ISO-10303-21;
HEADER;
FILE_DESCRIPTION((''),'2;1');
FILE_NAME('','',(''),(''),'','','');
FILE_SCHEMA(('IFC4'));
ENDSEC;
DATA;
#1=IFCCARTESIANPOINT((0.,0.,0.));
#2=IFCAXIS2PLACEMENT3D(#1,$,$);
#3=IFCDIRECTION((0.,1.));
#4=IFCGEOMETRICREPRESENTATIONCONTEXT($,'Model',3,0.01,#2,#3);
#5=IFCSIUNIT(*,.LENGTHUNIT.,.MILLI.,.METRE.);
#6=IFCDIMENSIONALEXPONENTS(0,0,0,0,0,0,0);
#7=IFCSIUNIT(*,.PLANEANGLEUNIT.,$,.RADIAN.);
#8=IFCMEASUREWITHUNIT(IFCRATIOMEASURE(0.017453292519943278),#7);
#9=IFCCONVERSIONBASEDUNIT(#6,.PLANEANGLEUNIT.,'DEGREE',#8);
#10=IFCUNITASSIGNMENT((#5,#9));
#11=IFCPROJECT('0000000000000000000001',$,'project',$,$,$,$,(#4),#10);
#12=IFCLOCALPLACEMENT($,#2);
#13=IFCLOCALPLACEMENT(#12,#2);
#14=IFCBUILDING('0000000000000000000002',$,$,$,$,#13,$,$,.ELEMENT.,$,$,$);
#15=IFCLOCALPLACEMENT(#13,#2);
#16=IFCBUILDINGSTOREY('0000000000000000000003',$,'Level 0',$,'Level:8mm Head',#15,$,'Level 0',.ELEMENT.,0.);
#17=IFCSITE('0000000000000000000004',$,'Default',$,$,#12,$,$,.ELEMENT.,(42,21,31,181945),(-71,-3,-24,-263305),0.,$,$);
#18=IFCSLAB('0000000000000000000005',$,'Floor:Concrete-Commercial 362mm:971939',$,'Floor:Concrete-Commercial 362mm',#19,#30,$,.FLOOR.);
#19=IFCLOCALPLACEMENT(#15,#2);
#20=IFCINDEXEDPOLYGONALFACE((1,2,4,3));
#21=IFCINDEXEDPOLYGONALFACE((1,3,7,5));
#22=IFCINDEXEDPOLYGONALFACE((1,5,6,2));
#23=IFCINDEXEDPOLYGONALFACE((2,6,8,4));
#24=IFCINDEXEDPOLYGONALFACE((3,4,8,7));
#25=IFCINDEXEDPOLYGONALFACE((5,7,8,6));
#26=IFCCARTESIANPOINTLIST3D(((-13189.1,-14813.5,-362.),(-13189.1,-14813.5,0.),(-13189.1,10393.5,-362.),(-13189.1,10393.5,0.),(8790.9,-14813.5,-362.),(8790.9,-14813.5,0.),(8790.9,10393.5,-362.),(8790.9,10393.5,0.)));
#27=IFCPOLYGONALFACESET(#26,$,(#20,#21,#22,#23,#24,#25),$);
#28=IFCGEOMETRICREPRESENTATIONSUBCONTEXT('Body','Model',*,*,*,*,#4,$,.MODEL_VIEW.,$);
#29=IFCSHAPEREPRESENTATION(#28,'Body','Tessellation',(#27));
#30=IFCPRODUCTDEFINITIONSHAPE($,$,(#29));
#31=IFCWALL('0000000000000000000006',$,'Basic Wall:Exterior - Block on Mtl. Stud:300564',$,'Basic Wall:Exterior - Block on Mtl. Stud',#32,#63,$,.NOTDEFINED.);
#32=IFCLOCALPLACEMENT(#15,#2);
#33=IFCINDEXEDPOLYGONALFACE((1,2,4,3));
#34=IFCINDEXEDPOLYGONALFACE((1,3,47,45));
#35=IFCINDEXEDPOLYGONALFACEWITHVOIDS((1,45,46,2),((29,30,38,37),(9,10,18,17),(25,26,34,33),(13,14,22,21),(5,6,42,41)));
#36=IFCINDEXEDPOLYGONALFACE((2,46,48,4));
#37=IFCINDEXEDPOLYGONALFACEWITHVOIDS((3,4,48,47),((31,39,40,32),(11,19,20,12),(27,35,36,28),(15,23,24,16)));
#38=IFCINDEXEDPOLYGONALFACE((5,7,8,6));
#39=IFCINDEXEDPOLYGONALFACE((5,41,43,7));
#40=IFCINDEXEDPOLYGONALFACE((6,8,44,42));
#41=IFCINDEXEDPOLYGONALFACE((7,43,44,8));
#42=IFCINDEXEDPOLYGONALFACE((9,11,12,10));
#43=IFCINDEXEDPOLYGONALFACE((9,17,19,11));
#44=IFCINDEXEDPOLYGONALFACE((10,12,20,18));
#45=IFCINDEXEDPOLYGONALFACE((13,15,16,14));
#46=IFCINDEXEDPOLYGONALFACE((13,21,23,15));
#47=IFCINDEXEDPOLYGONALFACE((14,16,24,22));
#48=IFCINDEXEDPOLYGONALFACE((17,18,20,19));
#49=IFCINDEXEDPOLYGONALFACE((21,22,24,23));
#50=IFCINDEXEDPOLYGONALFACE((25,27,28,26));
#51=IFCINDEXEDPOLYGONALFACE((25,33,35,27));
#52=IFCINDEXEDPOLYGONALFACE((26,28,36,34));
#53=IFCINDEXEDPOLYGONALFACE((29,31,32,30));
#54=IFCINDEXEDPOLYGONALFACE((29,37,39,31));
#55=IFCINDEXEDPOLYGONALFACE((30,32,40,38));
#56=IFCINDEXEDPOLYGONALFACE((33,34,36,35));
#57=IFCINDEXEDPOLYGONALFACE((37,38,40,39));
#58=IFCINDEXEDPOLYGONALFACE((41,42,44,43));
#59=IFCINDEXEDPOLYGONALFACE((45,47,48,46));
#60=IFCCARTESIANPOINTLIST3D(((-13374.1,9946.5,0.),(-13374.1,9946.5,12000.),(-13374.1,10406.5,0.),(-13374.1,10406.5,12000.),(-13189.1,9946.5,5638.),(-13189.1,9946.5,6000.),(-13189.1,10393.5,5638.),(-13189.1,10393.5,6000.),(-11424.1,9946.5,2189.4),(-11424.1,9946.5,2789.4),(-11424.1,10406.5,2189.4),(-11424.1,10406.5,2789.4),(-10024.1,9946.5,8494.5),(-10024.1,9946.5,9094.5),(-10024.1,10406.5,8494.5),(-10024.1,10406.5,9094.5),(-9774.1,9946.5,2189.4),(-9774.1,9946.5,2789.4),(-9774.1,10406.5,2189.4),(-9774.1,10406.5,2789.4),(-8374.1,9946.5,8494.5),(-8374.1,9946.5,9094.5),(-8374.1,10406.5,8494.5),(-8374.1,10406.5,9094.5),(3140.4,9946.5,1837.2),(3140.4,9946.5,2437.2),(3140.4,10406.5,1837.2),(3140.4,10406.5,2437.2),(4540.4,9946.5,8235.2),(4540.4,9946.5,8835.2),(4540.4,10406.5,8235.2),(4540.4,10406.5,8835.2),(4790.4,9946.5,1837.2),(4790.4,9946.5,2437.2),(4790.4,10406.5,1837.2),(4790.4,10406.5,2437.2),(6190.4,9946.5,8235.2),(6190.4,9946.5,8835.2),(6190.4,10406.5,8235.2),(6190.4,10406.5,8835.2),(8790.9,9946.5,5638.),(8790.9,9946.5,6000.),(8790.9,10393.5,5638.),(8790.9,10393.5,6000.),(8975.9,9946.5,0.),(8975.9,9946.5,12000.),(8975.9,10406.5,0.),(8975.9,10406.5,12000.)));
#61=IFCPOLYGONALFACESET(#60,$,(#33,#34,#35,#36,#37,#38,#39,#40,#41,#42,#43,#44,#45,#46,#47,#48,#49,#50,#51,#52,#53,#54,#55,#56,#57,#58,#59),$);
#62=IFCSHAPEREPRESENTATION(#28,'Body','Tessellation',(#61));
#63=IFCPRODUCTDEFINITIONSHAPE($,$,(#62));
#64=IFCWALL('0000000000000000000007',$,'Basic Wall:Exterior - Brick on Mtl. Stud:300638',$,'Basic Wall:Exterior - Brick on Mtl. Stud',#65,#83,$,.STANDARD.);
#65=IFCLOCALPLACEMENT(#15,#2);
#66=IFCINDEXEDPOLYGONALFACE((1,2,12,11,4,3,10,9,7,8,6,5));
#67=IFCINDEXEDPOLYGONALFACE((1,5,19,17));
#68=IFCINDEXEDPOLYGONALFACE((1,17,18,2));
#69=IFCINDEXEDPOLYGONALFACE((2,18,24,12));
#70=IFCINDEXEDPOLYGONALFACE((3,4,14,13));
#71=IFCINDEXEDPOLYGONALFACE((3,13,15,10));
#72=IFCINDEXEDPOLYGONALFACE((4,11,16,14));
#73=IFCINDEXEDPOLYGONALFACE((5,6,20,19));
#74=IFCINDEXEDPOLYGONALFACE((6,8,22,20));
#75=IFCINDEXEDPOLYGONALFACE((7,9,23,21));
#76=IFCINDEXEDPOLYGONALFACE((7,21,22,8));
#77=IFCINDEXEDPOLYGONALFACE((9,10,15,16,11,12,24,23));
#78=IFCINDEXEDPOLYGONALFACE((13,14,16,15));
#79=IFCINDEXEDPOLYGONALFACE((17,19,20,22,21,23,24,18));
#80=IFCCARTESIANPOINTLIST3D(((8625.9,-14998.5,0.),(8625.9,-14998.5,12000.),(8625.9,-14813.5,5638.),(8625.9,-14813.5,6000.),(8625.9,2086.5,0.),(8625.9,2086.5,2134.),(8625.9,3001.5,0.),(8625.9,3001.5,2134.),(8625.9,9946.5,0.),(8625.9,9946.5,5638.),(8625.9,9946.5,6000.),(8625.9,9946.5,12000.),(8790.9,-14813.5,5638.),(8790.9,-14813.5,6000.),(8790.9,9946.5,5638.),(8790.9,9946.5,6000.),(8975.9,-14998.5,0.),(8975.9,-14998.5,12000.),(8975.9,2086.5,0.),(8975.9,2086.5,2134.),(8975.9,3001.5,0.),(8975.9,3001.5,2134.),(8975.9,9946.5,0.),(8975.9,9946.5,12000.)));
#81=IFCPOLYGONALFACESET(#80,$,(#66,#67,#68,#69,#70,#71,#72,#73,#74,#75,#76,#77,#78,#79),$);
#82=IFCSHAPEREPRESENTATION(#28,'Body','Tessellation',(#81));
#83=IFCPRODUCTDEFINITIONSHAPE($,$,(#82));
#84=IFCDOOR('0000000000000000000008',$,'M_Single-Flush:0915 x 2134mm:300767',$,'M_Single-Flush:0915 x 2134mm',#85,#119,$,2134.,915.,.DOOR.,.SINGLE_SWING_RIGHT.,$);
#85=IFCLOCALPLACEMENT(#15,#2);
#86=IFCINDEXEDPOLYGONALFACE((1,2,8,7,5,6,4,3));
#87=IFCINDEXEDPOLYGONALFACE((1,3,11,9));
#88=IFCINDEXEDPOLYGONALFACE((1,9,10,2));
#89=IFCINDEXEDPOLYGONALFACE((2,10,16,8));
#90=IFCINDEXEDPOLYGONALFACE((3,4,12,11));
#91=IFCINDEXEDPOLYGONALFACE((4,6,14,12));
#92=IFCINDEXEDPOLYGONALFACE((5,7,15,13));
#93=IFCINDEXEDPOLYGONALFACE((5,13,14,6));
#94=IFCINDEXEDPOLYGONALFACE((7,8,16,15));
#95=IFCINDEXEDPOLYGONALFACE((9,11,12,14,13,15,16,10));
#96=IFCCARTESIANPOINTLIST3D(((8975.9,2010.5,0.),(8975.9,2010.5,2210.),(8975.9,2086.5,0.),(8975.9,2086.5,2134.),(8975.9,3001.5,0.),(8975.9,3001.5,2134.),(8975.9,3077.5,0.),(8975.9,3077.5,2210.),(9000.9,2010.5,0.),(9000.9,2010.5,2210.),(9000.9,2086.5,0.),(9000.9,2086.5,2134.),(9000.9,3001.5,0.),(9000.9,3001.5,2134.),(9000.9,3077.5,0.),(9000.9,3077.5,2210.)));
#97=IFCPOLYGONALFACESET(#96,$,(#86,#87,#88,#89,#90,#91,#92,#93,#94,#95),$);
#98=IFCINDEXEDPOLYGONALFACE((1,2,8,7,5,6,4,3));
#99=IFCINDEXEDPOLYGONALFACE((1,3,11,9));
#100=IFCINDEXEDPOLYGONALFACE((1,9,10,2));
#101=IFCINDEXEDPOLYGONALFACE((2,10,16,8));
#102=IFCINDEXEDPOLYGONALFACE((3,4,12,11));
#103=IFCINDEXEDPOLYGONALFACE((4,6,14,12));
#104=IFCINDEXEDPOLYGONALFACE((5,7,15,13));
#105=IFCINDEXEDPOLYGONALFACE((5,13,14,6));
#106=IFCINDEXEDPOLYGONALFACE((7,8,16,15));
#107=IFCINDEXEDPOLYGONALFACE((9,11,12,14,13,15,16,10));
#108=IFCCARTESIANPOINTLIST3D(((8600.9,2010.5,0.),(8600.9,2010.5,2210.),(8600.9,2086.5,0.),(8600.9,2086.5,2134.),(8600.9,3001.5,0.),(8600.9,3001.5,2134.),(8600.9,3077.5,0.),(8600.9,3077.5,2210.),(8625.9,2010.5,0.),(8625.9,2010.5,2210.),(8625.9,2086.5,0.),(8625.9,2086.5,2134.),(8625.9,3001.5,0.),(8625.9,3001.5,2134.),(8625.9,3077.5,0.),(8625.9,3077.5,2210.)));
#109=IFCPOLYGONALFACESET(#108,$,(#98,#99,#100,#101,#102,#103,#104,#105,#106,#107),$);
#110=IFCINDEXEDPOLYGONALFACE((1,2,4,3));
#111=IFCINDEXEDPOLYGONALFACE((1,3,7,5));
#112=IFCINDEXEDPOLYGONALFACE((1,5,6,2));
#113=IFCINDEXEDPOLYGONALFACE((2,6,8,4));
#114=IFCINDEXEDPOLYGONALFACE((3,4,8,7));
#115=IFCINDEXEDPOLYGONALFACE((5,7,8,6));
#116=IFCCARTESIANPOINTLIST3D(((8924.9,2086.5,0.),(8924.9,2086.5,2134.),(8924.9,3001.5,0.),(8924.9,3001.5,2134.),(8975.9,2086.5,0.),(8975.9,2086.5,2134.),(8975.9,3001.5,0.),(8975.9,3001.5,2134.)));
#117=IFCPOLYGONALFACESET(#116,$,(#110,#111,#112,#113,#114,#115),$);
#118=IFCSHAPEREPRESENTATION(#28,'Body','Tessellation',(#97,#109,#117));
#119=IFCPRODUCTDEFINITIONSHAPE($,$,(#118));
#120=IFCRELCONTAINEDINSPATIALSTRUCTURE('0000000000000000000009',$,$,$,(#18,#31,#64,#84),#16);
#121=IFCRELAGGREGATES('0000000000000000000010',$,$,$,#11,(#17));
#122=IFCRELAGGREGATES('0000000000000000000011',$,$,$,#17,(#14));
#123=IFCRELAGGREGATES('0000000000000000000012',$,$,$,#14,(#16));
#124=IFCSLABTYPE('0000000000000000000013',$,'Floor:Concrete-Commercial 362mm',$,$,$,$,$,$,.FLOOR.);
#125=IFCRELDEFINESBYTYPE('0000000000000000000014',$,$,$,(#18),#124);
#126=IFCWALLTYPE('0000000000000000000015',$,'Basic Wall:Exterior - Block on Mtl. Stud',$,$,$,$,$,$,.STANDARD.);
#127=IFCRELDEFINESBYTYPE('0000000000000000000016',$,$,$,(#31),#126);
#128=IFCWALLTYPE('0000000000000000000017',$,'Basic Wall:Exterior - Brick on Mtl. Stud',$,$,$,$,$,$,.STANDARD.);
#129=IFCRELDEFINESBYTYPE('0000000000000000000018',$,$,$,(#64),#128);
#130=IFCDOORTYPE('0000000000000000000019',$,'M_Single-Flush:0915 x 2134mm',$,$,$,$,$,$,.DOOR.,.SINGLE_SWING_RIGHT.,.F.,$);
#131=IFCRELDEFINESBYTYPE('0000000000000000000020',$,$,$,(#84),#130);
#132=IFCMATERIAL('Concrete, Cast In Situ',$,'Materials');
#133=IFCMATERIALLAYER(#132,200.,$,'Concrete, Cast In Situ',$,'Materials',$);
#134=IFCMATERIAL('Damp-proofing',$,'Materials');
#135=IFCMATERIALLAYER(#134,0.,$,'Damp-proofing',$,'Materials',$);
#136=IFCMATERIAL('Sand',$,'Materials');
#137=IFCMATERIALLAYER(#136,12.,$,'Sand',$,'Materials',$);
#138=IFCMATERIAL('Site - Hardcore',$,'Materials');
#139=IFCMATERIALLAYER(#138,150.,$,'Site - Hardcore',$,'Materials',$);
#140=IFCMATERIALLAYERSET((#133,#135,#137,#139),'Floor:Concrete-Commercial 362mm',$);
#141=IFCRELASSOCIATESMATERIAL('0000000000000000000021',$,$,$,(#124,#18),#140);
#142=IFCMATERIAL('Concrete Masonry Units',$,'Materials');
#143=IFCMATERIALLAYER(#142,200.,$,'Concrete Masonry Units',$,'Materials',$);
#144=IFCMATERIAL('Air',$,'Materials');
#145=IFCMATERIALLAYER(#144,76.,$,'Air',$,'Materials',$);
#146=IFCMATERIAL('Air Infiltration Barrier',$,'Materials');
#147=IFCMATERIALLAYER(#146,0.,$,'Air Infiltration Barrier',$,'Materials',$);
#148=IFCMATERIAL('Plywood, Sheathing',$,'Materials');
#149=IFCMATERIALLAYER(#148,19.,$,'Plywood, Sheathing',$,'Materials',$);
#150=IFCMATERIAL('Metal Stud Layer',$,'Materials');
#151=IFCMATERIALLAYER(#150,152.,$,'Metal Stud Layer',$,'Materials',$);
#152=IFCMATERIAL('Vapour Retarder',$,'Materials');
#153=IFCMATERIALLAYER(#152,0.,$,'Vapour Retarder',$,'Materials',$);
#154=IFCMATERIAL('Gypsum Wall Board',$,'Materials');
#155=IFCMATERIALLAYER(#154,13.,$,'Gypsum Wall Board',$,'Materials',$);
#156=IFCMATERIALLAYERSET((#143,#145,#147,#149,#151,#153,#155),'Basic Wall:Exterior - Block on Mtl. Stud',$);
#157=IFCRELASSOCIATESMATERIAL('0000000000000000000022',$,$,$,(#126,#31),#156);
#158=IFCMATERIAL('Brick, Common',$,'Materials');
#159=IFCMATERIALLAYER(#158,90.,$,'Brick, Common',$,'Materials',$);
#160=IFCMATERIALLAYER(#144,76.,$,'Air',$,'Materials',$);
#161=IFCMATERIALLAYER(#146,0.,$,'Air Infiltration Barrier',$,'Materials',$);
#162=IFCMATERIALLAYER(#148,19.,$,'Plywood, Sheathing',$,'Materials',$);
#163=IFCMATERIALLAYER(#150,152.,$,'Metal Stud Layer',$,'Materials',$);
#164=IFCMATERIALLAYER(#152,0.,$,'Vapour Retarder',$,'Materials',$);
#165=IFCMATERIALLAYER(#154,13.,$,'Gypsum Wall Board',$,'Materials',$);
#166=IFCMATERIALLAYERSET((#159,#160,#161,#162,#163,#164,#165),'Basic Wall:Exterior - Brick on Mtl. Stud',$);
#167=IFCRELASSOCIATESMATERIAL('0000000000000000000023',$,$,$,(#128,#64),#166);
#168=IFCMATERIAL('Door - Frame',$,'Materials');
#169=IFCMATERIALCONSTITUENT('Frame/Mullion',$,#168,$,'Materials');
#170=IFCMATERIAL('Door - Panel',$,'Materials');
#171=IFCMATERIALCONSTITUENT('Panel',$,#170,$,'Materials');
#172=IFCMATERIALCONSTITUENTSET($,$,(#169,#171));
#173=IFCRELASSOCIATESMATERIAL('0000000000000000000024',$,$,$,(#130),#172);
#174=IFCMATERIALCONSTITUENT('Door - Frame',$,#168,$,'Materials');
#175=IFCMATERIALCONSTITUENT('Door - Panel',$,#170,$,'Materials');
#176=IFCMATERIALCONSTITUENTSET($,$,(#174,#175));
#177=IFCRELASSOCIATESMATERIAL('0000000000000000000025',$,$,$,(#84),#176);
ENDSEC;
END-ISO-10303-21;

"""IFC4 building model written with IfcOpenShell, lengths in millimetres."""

from ifc_helpers import new_model, entity, si_unit, converted_unit, direction, frame, frame_2d, origin, place, context, subcontext, project, spatial, polyline, rectangle, outline, extrude, source, transform, mapped, material, layer, layer_set, layer_usage, constituent, constituent_set, type_object, type_shapes, element, fill, save


model = new_model("IFC4")

# Units and contexts
model_context = context("Model", 3, precision=0.01, world=origin(), true_north=direction((0.0, 1.0)))
body_context = subcontext(model_context, "Body", "Model", "MODEL_VIEW")
ifc_project = project(units=[si_unit("LENGTHUNIT", "METRE", prefix="MILLI"), converted_unit("PLANEANGLEUNIT", "DEGREE", entity("IfcRatioMeasure", 0.017453292519943278), si_unit("PLANEANGLEUNIT", "RADIAN"), dimensions=[0, 0, 0, 0, 0, 0, 0])], contexts=[model_context])

# Site, building, storey
site_placement = place(None, origin())
site = spatial("IfcSite", under=ifc_project, at=site_placement, Name="Default", CompositionType="ELEMENT", RefLatitude=(42, 21, 31, 181945), RefLongitude=(-71, -3, -24, -263305), RefElevation=0.0)
building_placement = place(site_placement, origin())
building = spatial("IfcBuilding", under=site, at=building_placement, CompositionType="ELEMENT")
storey_placement = place(building_placement, origin())
storey = spatial("IfcBuildingStorey", under=building, at=storey_placement, Name="Level 0", ObjectType="Level:8mm Head", LongName="Level 0", CompositionType="ELEMENT", Elevation=0.0)

# Slab
ifc_material_1 = material(Name="Concrete, Cast In Situ", Category="Materials")
ifc_layer_1 = layer(ifc_material_1, 200.0, Name="Concrete, Cast In Situ", Category="Materials")
ifc_material_2 = material(Name="Damp-proofing", Category="Materials")
ifc_layer_2 = layer(ifc_material_2, 0.0, Name="Damp-proofing", Category="Materials")
ifc_material_3 = material(Name="Sand", Category="Materials")
ifc_layer_3 = layer(ifc_material_3, 12.0, Name="Sand", Category="Materials")
ifc_material_4 = material(Name="Site - Hardcore", Category="Materials")
ifc_layer_4 = layer(ifc_material_4, 150.0, Name="Site - Hardcore", Category="Materials")
ifc_layer_set_1 = layer_set([ifc_layer_1, ifc_layer_2, ifc_layer_3, ifc_layer_4], Name="Floor:Concrete-Commercial 362mm")
ifc_layer_usage_1 = layer_usage(ifc_layer_set_1, "AXIS3", "POSITIVE", 0.0)
slab_type = type_object("IfcSlabType", Name="Floor:Concrete-Commercial 362mm", PredefinedType="FLOOR", material=ifc_layer_set_1)
slab_placement = place(storey_placement, origin())
element("IfcSlab", 1, at=slab_placement, inside=storey, type_object=slab_type, material=ifc_layer_usage_1, Name="Floor:Concrete-Commercial 362mm:971939", ObjectType="Floor:Concrete-Commercial 362mm", PredefinedType="FLOOR", context=body_context, shape_type="SweptSolid", body=[
    extrude(rectangle(XDim=25207.0, YDim=21980.0, at=frame_2d((0.0, 0.0), x_axis=(1.0, 0.0))), frame((-2199.1, -2210.0, 0.0), z_axis=(0.0, 0.0, -1.0), x_axis=(0.0, 1.0, 0.0)), (0.0, 0.0, 1.0), 362.0),
])

# Wall, openings
ifc_material_5 = material(Name="Concrete Masonry Units", Category="Materials")
ifc_layer_5 = layer(ifc_material_5, 200.0, Name="Concrete Masonry Units", Category="Materials")
ifc_material_6 = material(Name="Air", Category="Materials")
ifc_layer_6 = layer(ifc_material_6, 76.0, Name="Air", Category="Materials")
ifc_material_7 = material(Name="Air Infiltration Barrier", Category="Materials")
ifc_layer_7 = layer(ifc_material_7, 0.0, Name="Air Infiltration Barrier", Category="Materials")
ifc_material_8 = material(Name="Plywood, Sheathing", Category="Materials")
ifc_layer_8 = layer(ifc_material_8, 19.0, Name="Plywood, Sheathing", Category="Materials")
ifc_material_9 = material(Name="Metal Stud Layer", Category="Materials")
ifc_layer_9 = layer(ifc_material_9, 152.0, Name="Metal Stud Layer", Category="Materials")
ifc_material_10 = material(Name="Vapour Retarder", Category="Materials")
ifc_layer_10 = layer(ifc_material_10, 0.0, Name="Vapour Retarder", Category="Materials")
ifc_material_11 = material(Name="Gypsum Wall Board", Category="Materials")
ifc_layer_11 = layer(ifc_material_11, 13.0, Name="Gypsum Wall Board", Category="Materials")
ifc_layer_set_2 = layer_set([ifc_layer_5, ifc_layer_6, ifc_layer_7, ifc_layer_8, ifc_layer_9, ifc_layer_10, ifc_layer_11], Name="Basic Wall:Exterior - Block on Mtl. Stud")
ifc_layer_usage_2 = layer_usage(ifc_layer_set_2, "AXIS2", "POSITIVE", -230.0)
wall_type_1 = type_object("IfcWallType", Name="Basic Wall:Exterior - Block on Mtl. Stud", PredefinedType="STANDARD", material=ifc_layer_set_2)
wall_1_placement = place(storey_placement, frame((-13374.1, 10176.5, 0.0)))
wall_1 = element("IfcWall", 2, at=wall_1_placement, inside=storey, type_object=wall_type_1, material=ifc_layer_usage_2, Name="Basic Wall:Exterior - Block on Mtl. Stud:300564", ObjectType="Basic Wall:Exterior - Block on Mtl. Stud", PredefinedType="NOTDEFINED", context=body_context, shape_type="SweptSolid", body=[
    extrude(rectangle(XDim=22350.0, YDim=460.0, at=frame_2d((11175.0, 0.0), x_axis=(-1.0, 0.0))), origin(), (0.0, 0.0, 1.0), 12000.0),
])
opening_1_placement = place(storey_placement, frame((-13374.1, 10176.5, 0.0)))
element("IfcOpeningElement", 3, at=opening_1_placement, cuts=wall_1, PredefinedType="OPENING", context=body_context, shape_type="SweptSolid", body=[
    extrude(rectangle(XDim=21980.0, YDim=447.0, at=frame_2d((0.0, -74.5), x_axis=(1.0, 0.0))), frame((11175.0, -81.0, 5638.0), z_axis=(0.0, 0.0, 1.0), x_axis=(-1.0, 0.0, 0.0)), (0.0, 0.0, 1.0), 362.0),
])
opening_2_placement = place(wall_1_placement, frame((16514.5, -230.0, 1837.2)))
element("IfcOpeningElement", 4, at=opening_2_placement, cuts=wall_1, PredefinedType="OPENING", context=body_context, shape_type="SweptSolid", body=[
    extrude(rectangle(XDim=600.0, YDim=1650.0, at=frame_2d((300.0, 825.0), x_axis=(-1.0, 0.0))), frame((0.0, 0.0, 0.0), z_axis=(0.0, 1.0, 0.0), x_axis=(0.0, 0.0, 1.0)), (0.0, 0.0, 1.0), 460.0),
])
opening_3_placement = place(wall_1_placement, frame((1950.0, -230.0, 2189.4)))
element("IfcOpeningElement", 5, at=opening_3_placement, cuts=wall_1, PredefinedType="OPENING", context=body_context, shape_type="SweptSolid", body=[
    extrude(rectangle(XDim=600.0, YDim=1650.0, at=frame_2d((300.0, 825.0), x_axis=(-1.0, 0.0))), frame((0.0, 0.0, 0.0), z_axis=(0.0, 1.0, 0.0), x_axis=(0.0, 0.0, 1.0)), (0.0, 0.0, 1.0), 460.0),
])
opening_4_placement = place(wall_1_placement, frame((17914.5, -230.0, 8235.2)))
element("IfcOpeningElement", 6, at=opening_4_placement, cuts=wall_1, PredefinedType="OPENING", context=body_context, shape_type="SweptSolid", body=[
    extrude(rectangle(XDim=600.0, YDim=1650.0, at=frame_2d((300.0, 825.0), x_axis=(-1.0, 0.0))), frame((0.0, 0.0, 0.0), z_axis=(0.0, 1.0, 0.0), x_axis=(0.0, 0.0, 1.0)), (0.0, 0.0, 1.0), 460.0),
])
opening_5_placement = place(wall_1_placement, frame((3350.0, -230.0, 8494.5)))
element("IfcOpeningElement", 7, at=opening_5_placement, cuts=wall_1, PredefinedType="OPENING", context=body_context, shape_type="SweptSolid", body=[
    extrude(rectangle(XDim=600.0, YDim=1650.0, at=frame_2d((300.0, 825.0), x_axis=(-1.0, 0.0))), frame((0.0, 0.0, 0.0), z_axis=(0.0, 1.0, 0.0), x_axis=(0.0, 0.0, 1.0)), (0.0, 0.0, 1.0), 460.0),
])

# Wall, openings, door
ifc_material_12 = material(Name="Brick, Common", Category="Materials")
ifc_layer_12 = layer(ifc_material_12, 90.0, Name="Brick, Common", Category="Materials")
ifc_layer_13 = layer(ifc_material_6, 76.0, Name="Air", Category="Materials")
ifc_layer_14 = layer(ifc_material_7, 0.0, Name="Air Infiltration Barrier", Category="Materials")
ifc_layer_15 = layer(ifc_material_8, 19.0, Name="Plywood, Sheathing", Category="Materials")
ifc_layer_16 = layer(ifc_material_9, 152.0, Name="Metal Stud Layer", Category="Materials")
ifc_layer_17 = layer(ifc_material_10, 0.0, Name="Vapour Retarder", Category="Materials")
ifc_layer_18 = layer(ifc_material_11, 13.0, Name="Gypsum Wall Board", Category="Materials")
ifc_layer_set_3 = layer_set([ifc_layer_12, ifc_layer_13, ifc_layer_14, ifc_layer_15, ifc_layer_16, ifc_layer_17, ifc_layer_18], Name="Basic Wall:Exterior - Brick on Mtl. Stud")
ifc_layer_usage_3 = layer_usage(ifc_layer_set_3, "AXIS2", "NEGATIVE", 175.0)
wall_type_2 = type_object("IfcWallType", Name="Basic Wall:Exterior - Brick on Mtl. Stud", PredefinedType="STANDARD", material=ifc_layer_set_3)
wall_2_placement = place(storey_placement, frame((8800.9, 9946.5, 0.0), z_axis=(0.0, 0.0, 1.0), x_axis=(0.0, -1.0, 0.0)))
wall_2 = element("IfcWall", 8, at=wall_2_placement, inside=storey, type_object=wall_type_2, material=ifc_layer_usage_3, Name="Basic Wall:Exterior - Brick on Mtl. Stud:300638", ObjectType="Basic Wall:Exterior - Brick on Mtl. Stud", PredefinedType="STANDARD", context=body_context, shape_type="SweptSolid", body=[
    extrude(rectangle(XDim=24945.0, YDim=350.0, at=frame_2d((12472.5, 0.0), x_axis=(-1.0, 0.0))), origin(), (0.0, 0.0, 1.0), 12000.0),
])
opening_6_placement = place(storey_placement, frame((8800.9, 9946.5, 0.0), z_axis=(0.0, 0.0, 1.0), x_axis=(0.0, -1.0, 0.0)))
element("IfcOpeningElement", 9, at=opening_6_placement, cuts=wall_2, PredefinedType="OPENING", context=body_context, shape_type="SweptSolid", body=[
    extrude(rectangle(XDim=165.0, YDim=24760.0, at=frame_2d((16.5, 2443.0), x_axis=(1.0, 0.0))), frame((14823.0, -109.0, 5638.0), z_axis=(0.0, 0.0, 1.0), x_axis=(0.0, 1.0, 0.0)), (0.0, 0.0, 1.0), 362.0),
])
opening_7_placement = place(wall_2_placement, frame((6945.0, -175.0, 0.0)))
opening_7 = element("IfcOpeningElement", 10, at=opening_7_placement, cuts=wall_2, PredefinedType="OPENING", context=body_context, shape_type="SweptSolid", body=[
    extrude(rectangle(XDim=915.0, YDim=2134.0, at=frame_2d((1067.0, 457.5), x_axis=(0.0, 1.0))), frame((0.0, 0.0, 0.0), z_axis=(0.0, 1.0, 0.0), x_axis=(0.0, 0.0, 1.0)), (0.0, 0.0, 1.0), 350.0),
])
ifc_material_13 = material(Name="Door - Frame", Category="Materials")
ifc_constituent_1 = constituent(ifc_material_13, Name="Door - Frame", Category="Materials")
ifc_material_14 = material(Name="Door - Panel", Category="Materials")
ifc_constituent_2 = constituent(ifc_material_14, Name="Door - Panel", Category="Materials")
ifc_constituent_set_1 = constituent_set(constituents=[ifc_constituent_1, ifc_constituent_2])
ifc_constituent_3 = constituent(ifc_material_13, Name="Frame/Mullion", Category="Materials")
ifc_constituent_4 = constituent(ifc_material_14, Name="Panel", Category="Materials")
ifc_constituent_set_2 = constituent_set(constituents=[ifc_constituent_3, ifc_constituent_4])
door_type_1 = type_object("IfcDoorType", Name="M_Single-Flush:0915 x 2134mm", OperationType="SINGLE_SWING_RIGHT", ParameterTakesPrecedence=False, PredefinedType="DOOR", material=ifc_constituent_set_2)
shared_shape_1 = source(origin(), body_context, "Body", "SweptSolid", [
    extrude(outline(polyline([(-533.5, -1124.0), (533.5, -1124.0), (533.5, 1086.0), (457.5, 1086.0), (457.5, -1048.0), (-457.5, -1048.0), (-457.5, 1086.0), (-533.5, 1086.0), (-533.5, -1124.0)])), frame((457.5, 350.0, 1086.0), z_axis=(0.0, 1.0, 0.0), x_axis=(1.0, 0.0, 0.0)), (0.0, 0.0, 1.0), 25.0),
    extrude(outline(polyline([(-1124.0, -533.5), (1086.0, -533.5), (1086.0, -457.5), (-1048.0, -457.5), (-1048.0, 457.5), (1086.0, 457.5), (1086.0, 533.5), (-1124.0, 533.5), (-1124.0, -533.5)])), frame((457.5, -25.0, 1086.0), z_axis=(0.0, 1.0, 0.0), x_axis=(0.0, 0.0, -1.0)), (0.0, 0.0, 1.0), 25.0),
    extrude(rectangle(XDim=51.0, YDim=915.0, at=frame_2d((0.0, 0.0), x_axis=(1.0, 0.0))), frame((457.5, 324.5, 0.0), z_axis=(0.0, 0.0, 1.0), x_axis=(0.0, 1.0, 0.0)), (0.0, 0.0, 1.0), 2134.0),
])
type_shapes(door_type_1, [shared_shape_1])
door_1_placement = place(opening_7_placement, origin())
door_1 = element("IfcDoor", 11, at=door_1_placement, inside=storey, type_object=door_type_1, material=ifc_constituent_set_1, Name="M_Single-Flush:0915 x 2134mm:300767", ObjectType="M_Single-Flush:0915 x 2134mm", OperationType="SINGLE_SWING_RIGHT", OverallHeight=2134.0, OverallWidth=915.0, PredefinedType="DOOR", context=body_context, shape_type="MappedRepresentation", body=[
    mapped(shared_shape_1, transform((0.0, 0.0, 0.0), scale=1.0)),
])
fill(opening_7, door_1)

save(model, "model.ifc")
